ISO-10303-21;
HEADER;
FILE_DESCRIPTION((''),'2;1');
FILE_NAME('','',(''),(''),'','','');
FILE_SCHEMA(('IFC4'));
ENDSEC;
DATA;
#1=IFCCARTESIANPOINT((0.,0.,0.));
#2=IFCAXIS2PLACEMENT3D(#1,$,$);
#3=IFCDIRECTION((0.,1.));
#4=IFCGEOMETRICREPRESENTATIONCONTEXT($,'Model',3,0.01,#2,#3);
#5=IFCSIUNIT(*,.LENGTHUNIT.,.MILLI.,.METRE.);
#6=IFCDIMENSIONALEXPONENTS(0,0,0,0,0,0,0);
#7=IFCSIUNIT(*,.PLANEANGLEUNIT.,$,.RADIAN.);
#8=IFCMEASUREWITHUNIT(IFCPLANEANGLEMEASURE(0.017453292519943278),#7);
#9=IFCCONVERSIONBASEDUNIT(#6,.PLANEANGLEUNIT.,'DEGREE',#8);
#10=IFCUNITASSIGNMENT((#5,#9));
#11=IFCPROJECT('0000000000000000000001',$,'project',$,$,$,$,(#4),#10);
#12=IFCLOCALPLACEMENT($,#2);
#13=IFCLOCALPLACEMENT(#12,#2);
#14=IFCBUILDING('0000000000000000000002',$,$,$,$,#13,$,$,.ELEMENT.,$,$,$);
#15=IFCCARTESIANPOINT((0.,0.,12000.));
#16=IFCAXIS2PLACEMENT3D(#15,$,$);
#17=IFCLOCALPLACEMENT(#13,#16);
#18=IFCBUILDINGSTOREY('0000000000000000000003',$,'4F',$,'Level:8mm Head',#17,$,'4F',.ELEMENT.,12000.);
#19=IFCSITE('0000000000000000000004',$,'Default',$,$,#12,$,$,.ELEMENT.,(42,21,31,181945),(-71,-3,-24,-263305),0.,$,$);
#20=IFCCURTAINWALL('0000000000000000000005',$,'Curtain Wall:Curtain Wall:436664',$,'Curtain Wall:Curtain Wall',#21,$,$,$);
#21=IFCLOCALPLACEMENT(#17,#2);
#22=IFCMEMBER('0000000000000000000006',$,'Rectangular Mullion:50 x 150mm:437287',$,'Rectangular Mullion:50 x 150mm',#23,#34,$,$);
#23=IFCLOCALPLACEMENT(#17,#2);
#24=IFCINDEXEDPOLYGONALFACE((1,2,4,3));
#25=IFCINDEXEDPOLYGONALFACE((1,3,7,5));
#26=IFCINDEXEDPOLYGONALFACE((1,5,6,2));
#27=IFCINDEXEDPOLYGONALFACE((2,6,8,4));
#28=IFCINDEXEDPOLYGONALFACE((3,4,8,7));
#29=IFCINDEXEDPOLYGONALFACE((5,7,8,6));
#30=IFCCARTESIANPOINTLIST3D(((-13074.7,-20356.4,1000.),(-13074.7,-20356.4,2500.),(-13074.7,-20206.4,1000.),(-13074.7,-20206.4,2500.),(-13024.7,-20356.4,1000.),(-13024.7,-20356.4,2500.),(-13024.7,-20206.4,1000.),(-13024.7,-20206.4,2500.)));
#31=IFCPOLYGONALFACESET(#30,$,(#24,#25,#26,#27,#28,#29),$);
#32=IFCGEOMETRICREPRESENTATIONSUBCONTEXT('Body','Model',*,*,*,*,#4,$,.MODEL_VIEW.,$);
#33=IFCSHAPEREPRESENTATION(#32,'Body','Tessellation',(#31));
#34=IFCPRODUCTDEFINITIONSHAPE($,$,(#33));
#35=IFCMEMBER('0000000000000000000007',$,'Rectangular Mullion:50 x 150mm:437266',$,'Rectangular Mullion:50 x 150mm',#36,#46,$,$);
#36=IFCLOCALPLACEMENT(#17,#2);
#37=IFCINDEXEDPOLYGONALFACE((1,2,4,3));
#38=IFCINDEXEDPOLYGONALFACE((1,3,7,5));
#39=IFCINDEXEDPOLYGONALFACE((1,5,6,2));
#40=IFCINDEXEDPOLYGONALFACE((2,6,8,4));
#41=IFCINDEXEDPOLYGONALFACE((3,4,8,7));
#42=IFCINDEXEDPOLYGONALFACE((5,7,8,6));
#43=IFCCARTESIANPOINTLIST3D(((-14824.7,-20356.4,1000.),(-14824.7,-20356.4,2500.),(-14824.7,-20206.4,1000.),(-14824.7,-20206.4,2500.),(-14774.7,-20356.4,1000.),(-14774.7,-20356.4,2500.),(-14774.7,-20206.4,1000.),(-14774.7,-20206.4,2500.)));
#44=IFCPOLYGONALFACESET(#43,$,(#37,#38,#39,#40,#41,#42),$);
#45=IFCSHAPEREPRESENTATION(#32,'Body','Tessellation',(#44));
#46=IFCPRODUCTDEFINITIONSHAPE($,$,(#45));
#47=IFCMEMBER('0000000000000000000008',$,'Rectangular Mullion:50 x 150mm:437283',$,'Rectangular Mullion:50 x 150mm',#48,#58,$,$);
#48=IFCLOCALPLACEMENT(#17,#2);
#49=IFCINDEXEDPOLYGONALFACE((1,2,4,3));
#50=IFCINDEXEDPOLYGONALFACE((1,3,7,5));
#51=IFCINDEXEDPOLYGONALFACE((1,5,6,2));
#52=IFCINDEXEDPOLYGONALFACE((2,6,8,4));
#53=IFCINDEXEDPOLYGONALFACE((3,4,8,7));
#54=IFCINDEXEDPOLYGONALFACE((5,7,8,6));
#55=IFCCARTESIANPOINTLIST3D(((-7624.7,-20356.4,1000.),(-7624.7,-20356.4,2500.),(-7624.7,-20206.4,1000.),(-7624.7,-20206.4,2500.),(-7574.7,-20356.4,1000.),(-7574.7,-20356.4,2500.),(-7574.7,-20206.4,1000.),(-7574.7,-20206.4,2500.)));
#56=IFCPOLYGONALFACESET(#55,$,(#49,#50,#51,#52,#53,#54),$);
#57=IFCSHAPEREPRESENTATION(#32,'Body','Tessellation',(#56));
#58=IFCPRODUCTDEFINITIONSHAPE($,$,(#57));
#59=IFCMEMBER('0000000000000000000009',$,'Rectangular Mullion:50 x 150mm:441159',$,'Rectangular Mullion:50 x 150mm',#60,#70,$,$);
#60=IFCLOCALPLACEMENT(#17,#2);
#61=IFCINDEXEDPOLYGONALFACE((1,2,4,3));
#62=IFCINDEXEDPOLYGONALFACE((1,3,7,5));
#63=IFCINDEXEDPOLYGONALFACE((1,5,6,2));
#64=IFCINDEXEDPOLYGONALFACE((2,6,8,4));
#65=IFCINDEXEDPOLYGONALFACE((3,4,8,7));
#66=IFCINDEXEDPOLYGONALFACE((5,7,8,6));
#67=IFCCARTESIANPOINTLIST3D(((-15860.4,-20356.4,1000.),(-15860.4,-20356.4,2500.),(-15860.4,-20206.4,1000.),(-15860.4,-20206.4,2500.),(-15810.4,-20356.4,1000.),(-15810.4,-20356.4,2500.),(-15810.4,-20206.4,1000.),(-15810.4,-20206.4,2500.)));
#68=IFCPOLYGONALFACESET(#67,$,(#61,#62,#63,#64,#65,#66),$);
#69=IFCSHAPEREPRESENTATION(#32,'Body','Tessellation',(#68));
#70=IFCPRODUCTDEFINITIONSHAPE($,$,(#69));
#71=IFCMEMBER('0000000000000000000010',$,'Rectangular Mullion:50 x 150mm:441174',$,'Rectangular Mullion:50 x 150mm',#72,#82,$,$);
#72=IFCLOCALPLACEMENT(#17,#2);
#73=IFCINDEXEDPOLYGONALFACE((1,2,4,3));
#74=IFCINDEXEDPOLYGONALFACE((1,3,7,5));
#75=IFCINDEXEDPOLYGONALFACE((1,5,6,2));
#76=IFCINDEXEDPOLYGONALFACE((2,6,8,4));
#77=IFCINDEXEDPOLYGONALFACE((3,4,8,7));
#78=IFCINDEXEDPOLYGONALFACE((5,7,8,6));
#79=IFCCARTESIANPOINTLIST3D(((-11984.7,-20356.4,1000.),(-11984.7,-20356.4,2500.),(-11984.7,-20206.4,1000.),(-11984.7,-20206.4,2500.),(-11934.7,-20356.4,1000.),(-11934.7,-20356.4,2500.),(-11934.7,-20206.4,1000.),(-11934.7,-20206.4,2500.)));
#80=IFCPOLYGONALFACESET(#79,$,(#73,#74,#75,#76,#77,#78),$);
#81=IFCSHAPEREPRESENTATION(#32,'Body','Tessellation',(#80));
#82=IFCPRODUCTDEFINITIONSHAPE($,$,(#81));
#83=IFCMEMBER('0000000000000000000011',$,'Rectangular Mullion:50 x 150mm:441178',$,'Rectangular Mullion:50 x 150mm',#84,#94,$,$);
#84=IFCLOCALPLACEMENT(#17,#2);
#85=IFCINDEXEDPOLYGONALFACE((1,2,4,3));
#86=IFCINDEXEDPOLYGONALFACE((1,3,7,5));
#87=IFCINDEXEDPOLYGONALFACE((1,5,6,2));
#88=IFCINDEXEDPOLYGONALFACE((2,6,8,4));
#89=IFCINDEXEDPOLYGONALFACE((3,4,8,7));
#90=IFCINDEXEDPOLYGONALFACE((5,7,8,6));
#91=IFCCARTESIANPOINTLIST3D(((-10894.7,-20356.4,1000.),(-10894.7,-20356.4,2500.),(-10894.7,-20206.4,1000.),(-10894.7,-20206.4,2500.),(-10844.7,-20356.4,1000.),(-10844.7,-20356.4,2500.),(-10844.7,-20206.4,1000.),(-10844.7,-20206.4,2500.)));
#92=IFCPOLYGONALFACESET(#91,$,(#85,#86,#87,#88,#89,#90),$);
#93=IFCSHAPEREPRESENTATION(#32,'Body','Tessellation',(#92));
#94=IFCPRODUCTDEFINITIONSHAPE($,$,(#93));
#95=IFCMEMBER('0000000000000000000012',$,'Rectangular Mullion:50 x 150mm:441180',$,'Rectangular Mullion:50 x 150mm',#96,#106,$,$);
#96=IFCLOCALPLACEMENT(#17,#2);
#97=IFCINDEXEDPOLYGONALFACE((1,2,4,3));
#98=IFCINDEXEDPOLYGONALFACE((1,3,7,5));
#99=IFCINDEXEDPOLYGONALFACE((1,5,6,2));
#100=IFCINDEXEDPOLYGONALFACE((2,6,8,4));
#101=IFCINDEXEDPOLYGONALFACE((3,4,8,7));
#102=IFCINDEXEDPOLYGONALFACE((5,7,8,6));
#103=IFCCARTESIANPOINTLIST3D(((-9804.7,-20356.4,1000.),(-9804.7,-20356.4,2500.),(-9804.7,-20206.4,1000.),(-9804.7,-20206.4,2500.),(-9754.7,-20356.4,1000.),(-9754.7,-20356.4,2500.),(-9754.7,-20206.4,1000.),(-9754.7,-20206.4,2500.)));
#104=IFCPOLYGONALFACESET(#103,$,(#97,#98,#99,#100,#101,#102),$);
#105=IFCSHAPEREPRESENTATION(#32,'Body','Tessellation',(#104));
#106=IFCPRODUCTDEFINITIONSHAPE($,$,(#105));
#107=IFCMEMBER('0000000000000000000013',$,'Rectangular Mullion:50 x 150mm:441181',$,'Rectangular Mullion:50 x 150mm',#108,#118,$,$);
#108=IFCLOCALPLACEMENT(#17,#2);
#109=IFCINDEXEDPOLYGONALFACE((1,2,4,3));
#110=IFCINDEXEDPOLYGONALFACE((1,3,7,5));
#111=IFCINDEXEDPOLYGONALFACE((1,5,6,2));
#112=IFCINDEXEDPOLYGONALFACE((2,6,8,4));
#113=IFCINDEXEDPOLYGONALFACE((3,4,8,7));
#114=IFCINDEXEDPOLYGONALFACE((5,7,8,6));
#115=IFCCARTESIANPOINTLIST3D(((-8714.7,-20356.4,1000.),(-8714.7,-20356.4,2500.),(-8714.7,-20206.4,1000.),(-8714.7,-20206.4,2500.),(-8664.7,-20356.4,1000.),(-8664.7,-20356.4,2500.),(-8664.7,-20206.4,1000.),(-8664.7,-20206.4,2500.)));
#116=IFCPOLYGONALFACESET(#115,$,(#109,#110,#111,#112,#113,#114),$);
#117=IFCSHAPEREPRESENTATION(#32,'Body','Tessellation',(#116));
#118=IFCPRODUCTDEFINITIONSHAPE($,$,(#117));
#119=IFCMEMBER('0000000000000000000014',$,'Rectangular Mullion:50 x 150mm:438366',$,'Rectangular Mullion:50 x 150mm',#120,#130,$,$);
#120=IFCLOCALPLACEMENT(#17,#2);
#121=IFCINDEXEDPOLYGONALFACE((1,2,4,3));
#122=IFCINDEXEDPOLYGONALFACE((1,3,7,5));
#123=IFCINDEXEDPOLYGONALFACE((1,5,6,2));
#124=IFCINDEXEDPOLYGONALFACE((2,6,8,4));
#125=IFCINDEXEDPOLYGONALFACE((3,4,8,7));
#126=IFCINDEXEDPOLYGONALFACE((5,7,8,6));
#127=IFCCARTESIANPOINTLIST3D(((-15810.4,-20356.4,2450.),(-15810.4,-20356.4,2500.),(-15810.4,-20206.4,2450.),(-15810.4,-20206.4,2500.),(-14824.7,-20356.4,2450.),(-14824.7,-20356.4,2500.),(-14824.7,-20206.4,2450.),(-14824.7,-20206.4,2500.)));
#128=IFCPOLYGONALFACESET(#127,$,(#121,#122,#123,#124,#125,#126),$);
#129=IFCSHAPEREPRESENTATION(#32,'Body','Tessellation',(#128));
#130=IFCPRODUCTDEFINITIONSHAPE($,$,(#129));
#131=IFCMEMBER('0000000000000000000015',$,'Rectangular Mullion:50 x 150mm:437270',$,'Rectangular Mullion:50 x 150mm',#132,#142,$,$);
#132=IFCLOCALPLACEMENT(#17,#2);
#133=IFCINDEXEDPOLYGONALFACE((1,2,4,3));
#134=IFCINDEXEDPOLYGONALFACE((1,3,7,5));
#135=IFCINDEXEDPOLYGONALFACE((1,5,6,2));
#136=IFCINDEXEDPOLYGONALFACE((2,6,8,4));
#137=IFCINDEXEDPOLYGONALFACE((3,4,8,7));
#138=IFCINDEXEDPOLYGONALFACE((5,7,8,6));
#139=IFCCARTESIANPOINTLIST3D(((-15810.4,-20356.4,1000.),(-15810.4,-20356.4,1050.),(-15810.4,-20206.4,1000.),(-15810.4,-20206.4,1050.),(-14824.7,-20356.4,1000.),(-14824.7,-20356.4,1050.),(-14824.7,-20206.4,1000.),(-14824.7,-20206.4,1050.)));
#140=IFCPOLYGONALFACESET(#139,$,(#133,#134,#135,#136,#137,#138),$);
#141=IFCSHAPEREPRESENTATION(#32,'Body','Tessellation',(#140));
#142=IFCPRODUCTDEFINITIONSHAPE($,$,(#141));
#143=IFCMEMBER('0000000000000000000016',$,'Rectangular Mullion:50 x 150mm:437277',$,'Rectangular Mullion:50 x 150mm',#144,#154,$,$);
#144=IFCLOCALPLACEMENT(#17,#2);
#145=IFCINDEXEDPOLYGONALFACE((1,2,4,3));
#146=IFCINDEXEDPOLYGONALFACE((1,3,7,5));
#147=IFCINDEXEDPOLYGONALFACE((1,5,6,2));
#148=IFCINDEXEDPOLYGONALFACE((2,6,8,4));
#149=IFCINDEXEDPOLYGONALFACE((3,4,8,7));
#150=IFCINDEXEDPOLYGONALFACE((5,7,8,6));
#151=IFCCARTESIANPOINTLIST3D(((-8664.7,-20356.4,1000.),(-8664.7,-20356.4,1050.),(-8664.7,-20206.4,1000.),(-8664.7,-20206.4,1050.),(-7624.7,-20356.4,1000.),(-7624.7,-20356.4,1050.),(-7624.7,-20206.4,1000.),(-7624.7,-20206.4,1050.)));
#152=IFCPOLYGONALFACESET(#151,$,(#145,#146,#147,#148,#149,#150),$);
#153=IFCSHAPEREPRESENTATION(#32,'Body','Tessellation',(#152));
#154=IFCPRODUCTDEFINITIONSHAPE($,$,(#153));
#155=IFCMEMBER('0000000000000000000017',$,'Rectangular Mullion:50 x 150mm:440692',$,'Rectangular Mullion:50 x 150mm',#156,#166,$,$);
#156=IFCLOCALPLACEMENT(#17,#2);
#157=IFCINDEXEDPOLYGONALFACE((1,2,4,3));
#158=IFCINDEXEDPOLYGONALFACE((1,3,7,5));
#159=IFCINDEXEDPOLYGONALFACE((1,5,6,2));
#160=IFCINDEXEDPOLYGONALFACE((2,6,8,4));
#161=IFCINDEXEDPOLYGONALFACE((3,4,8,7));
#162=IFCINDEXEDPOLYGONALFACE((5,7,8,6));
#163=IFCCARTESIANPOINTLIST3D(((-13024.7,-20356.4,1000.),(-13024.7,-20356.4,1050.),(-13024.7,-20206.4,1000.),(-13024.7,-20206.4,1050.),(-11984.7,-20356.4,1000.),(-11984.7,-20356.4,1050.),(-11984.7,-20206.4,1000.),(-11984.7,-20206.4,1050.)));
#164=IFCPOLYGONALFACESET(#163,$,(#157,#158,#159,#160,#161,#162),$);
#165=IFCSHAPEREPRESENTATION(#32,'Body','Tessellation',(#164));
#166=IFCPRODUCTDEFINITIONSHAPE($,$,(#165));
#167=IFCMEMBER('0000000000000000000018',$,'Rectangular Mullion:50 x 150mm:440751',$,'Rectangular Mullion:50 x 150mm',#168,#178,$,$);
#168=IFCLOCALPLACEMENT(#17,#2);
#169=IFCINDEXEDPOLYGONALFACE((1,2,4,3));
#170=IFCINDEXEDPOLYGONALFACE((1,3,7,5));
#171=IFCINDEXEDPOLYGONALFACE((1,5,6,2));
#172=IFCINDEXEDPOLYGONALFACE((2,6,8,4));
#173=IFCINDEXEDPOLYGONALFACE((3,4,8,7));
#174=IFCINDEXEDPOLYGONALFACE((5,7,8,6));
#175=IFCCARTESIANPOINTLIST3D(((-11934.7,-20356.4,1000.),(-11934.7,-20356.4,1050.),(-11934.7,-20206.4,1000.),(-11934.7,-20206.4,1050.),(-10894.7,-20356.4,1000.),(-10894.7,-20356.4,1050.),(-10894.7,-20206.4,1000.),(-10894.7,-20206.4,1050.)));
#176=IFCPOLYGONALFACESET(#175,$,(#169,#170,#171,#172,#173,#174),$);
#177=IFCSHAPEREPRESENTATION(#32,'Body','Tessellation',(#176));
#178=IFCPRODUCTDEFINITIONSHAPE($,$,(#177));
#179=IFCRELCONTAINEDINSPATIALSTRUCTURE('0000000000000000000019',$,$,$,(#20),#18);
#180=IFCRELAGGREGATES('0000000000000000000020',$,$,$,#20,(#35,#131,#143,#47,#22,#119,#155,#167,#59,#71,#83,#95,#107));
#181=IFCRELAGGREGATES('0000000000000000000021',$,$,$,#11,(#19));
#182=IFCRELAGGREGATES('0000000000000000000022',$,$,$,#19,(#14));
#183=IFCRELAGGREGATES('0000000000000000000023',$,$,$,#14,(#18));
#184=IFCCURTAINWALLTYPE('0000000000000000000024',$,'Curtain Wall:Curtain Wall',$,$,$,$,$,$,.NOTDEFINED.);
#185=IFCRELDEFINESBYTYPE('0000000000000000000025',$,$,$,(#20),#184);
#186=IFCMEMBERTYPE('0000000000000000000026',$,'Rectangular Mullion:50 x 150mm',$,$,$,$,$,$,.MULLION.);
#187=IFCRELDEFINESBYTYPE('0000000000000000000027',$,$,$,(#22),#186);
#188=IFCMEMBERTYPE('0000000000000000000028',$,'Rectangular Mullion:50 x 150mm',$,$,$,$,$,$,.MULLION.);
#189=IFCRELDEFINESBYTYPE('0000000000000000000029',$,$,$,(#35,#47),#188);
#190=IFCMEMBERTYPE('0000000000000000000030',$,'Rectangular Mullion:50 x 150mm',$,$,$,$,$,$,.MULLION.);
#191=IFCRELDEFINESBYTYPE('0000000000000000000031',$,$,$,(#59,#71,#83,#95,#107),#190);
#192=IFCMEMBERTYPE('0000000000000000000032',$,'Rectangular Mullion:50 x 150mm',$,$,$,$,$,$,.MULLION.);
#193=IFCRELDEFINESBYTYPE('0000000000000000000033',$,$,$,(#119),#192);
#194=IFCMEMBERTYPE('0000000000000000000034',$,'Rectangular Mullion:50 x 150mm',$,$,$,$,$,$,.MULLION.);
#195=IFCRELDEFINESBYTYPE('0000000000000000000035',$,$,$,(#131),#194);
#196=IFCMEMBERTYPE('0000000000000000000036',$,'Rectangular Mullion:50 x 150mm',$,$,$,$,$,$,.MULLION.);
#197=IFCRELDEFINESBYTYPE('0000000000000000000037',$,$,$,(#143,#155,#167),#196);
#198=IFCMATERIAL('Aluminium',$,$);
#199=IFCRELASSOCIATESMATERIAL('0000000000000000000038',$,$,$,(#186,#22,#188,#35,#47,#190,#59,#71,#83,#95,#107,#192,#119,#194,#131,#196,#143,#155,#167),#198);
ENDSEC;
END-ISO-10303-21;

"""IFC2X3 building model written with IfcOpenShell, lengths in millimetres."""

from ifc_helpers import new_model, entity, si_unit, converted_unit, direction, frame, origin, origin_2d_with_axis, place, context, subcontext, project, spatial, rectangle, extrude, source, transform, mapped, material, type_object, type_shapes, element, aggregate, save


model = new_model("IFC2X3")

# Units and contexts
model_context = context("Model", 3, precision=0.01, world=origin(), true_north=direction((0.0, 1.0)))
body_context = subcontext(model_context, "Body", "Model", "MODEL_VIEW")
ifc_project = project(units=[si_unit("LENGTHUNIT", "METRE", prefix="MILLI"), converted_unit("PLANEANGLEUNIT", "DEGREE", entity("IfcPlaneAngleMeasure", 0.017453292519943278), si_unit("PLANEANGLEUNIT", "RADIAN"), dimensions=[0, 0, 0, 0, 0, 0, 0])], contexts=[model_context])

# Site, building, storey
site_placement = place(None, origin())
site = spatial("IfcSite", under=ifc_project, at=site_placement, Name="Default", CompositionType="ELEMENT", RefLatitude=(42, 21, 31, 181945), RefLongitude=(-71, -3, -24, -263305), RefElevation=0.0)
building_placement = place(site_placement, origin())
building = spatial("IfcBuilding", under=site, at=building_placement, CompositionType="ELEMENT")
storey_placement = place(building_placement, frame((0.0, 0.0, 12000.0)))
storey = spatial("IfcBuildingStorey", under=building, at=storey_placement, Name="4F", ObjectType="Level:8mm Head", LongName="4F", CompositionType="ELEMENT", Elevation=12000.0)

# Curtain wall, members
curtain_wall_type = type_object("IfcCurtainWallType", Name="Curtain Wall:Curtain Wall", PredefinedType="NOTDEFINED")
curtain_wall_placement = place(storey_placement, frame((0.0, 0.0, -12000.0)))
curtain_wall = element("IfcCurtainWall", 1, at=curtain_wall_placement, inside=storey, type_object=curtain_wall_type, Name="Curtain Wall:Curtain Wall:436664", ObjectType="Curtain Wall:Curtain Wall")
ifc_material_1 = material(Name="Aluminium")
member_type_1 = type_object("IfcMemberType", Name="Rectangular Mullion:50 x 150mm", PredefinedType="MULLION", material=ifc_material_1)
shared_shape_1 = source(origin(), body_context, "Body", "SweptSolid", [
    extrude(rectangle(XDim=50.0, YDim=150.0, at=origin_2d_with_axis()), frame((-25.0, 0.0, -1500.0), z_axis=(0.0, 0.0, 1.0), x_axis=(-1.0, 0.0, 0.0)), (0.0, 0.0, 1.0), 1500.0),
])
type_shapes(member_type_1, [shared_shape_1])
member_1_placement = place(curtain_wall_placement, frame((-13074.7, -20281.4, 13000.0), z_axis=(0.0, 0.0, -1.0), x_axis=(-1.0, 0.0, 0.0)))
member_1 = element("IfcMember", 2, at=member_1_placement, type_object=member_type_1, material=ifc_material_1, Name="Rectangular Mullion:50 x 150mm:437287", ObjectType="Rectangular Mullion:50 x 150mm", context=body_context, shape_type="MappedRepresentation", body=[
    mapped(shared_shape_1, transform((0.0, 0.0, 0.0), scale=1.0)),
])
member_type_2 = type_object("IfcMemberType", Name="Rectangular Mullion:50 x 150mm", PredefinedType="MULLION", material=ifc_material_1)
shared_shape_2 = source(origin(), body_context, "Body", "SweptSolid", [
    extrude(rectangle(XDim=50.0, YDim=150.0, at=origin_2d_with_axis()), frame((-25.0, 0.0, -1500.0), z_axis=(0.0, 0.0, 1.0), x_axis=(-1.0, 0.0, 0.0)), (0.0, 0.0, 1.0), 1500.0),
])
type_shapes(member_type_2, [shared_shape_2])
member_2_placement = place(curtain_wall_placement, frame((-14774.7, -20281.4, 14500.0)))
member_2 = element("IfcMember", 3, at=member_2_placement, type_object=member_type_2, material=ifc_material_1, Name="Rectangular Mullion:50 x 150mm:437266", ObjectType="Rectangular Mullion:50 x 150mm", context=body_context, shape_type="MappedRepresentation", body=[
    mapped(shared_shape_2, transform((0.0, 0.0, 0.0), scale=1.0)),
])
member_3_placement = place(curtain_wall_placement, frame((-7574.7, -20281.4, 14500.0)))
member_3 = element("IfcMember", 4, at=member_3_placement, type_object=member_type_2, material=ifc_material_1, Name="Rectangular Mullion:50 x 150mm:437283", ObjectType="Rectangular Mullion:50 x 150mm", context=body_context, shape_type="MappedRepresentation", body=[
    mapped(shared_shape_2, transform((0.0, 0.0, 0.0), scale=1.0)),
])
member_type_3 = type_object("IfcMemberType", Name="Rectangular Mullion:50 x 150mm", PredefinedType="MULLION", material=ifc_material_1)
shared_shape_3 = source(origin(), body_context, "Body", "SweptSolid", [
    extrude(rectangle(XDim=50.0, YDim=150.0, at=origin_2d_with_axis()), frame((0.0, 0.0, -1500.0), z_axis=(0.0, 0.0, 1.0), x_axis=(-1.0, 0.0, 0.0)), (0.0, 0.0, 1.0), 1500.0),
])
type_shapes(member_type_3, [shared_shape_3])
member_4_placement = place(curtain_wall_placement, frame((-15835.4, -20281.4, 13000.0), z_axis=(0.0, 0.0, -1.0), x_axis=(-1.0, 0.0, 0.0)))
member_4 = element("IfcMember", 5, at=member_4_placement, type_object=member_type_3, material=ifc_material_1, Name="Rectangular Mullion:50 x 150mm:441159", ObjectType="Rectangular Mullion:50 x 150mm", context=body_context, shape_type="MappedRepresentation", body=[
    mapped(shared_shape_3, transform((0.0, 0.0, 0.0), scale=1.0)),
])
member_5_placement = place(curtain_wall_placement, frame((-11959.7, -20281.4, 13000.0), z_axis=(0.0, 0.0, -1.0), x_axis=(-1.0, 0.0, 0.0)))
member_5 = element("IfcMember", 6, at=member_5_placement, type_object=member_type_3, material=ifc_material_1, Name="Rectangular Mullion:50 x 150mm:441174", ObjectType="Rectangular Mullion:50 x 150mm", context=body_context, shape_type="MappedRepresentation", body=[
    mapped(shared_shape_3, transform((0.0, 0.0, 0.0), scale=1.0)),
])
member_6_placement = place(curtain_wall_placement, frame((-10869.7, -20281.4, 13000.0), z_axis=(0.0, 0.0, -1.0), x_axis=(-1.0, 0.0, 0.0)))
member_6 = element("IfcMember", 7, at=member_6_placement, type_object=member_type_3, material=ifc_material_1, Name="Rectangular Mullion:50 x 150mm:441178", ObjectType="Rectangular Mullion:50 x 150mm", context=body_context, shape_type="MappedRepresentation", body=[
    mapped(shared_shape_3, transform((0.0, 0.0, 0.0), scale=1.0)),
])
member_7_placement = place(curtain_wall_placement, frame((-9779.7, -20281.4, 13000.0), z_axis=(0.0, 0.0, -1.0), x_axis=(-1.0, 0.0, 0.0)))
member_7 = element("IfcMember", 8, at=member_7_placement, type_object=member_type_3, material=ifc_material_1, Name="Rectangular Mullion:50 x 150mm:441180", ObjectType="Rectangular Mullion:50 x 150mm", context=body_context, shape_type="MappedRepresentation", body=[
    mapped(shared_shape_3, transform((0.0, 0.0, 0.0), scale=1.0)),
])
member_8_placement = place(curtain_wall_placement, frame((-8689.7, -20281.4, 13000.0), z_axis=(0.0, 0.0, -1.0), x_axis=(-1.0, 0.0, 0.0)))
member_8 = element("IfcMember", 9, at=member_8_placement, type_object=member_type_3, material=ifc_material_1, Name="Rectangular Mullion:50 x 150mm:441181", ObjectType="Rectangular Mullion:50 x 150mm", context=body_context, shape_type="MappedRepresentation", body=[
    mapped(shared_shape_3, transform((0.0, 0.0, 0.0), scale=1.0)),
])
member_type_4 = type_object("IfcMemberType", Name="Rectangular Mullion:50 x 150mm", PredefinedType="MULLION", material=ifc_material_1)
shared_shape_4 = source(origin(), body_context, "Body", "SweptSolid", [
    extrude(rectangle(XDim=50.0, YDim=150.0, at=origin_2d_with_axis()), frame((-25.0, 0.0, -985.7), z_axis=(0.0, 0.0, 1.0), x_axis=(-1.0, 0.0, 0.0)), (0.0, 0.0, 1.0), 985.7),
])
type_shapes(member_type_4, [shared_shape_4])
member_9_placement = place(curtain_wall_placement, frame((-15810.4, -20281.4, 14500.0), z_axis=(-1.0, 0.0, 0.0), x_axis=(0.0, 0.0, 1.0)))
member_9 = element("IfcMember", 10, at=member_9_placement, type_object=member_type_4, material=ifc_material_1, Name="Rectangular Mullion:50 x 150mm:438366", ObjectType="Rectangular Mullion:50 x 150mm", context=body_context, shape_type="MappedRepresentation", body=[
    mapped(shared_shape_4, transform((0.0, 0.0, 0.0), scale=1.0)),
])
member_type_5 = type_object("IfcMemberType", Name="Rectangular Mullion:50 x 150mm", PredefinedType="MULLION", material=ifc_material_1)
shared_shape_5 = source(origin(), body_context, "Body", "SweptSolid", [
    extrude(rectangle(XDim=50.0, YDim=150.0, at=origin_2d_with_axis()), frame((-25.0, 0.0, -985.7), z_axis=(0.0, 0.0, 1.0), x_axis=(-1.0, 0.0, 0.0)), (0.0, 0.0, 1.0), 985.7),
])
type_shapes(member_type_5, [shared_shape_5])
member_10_placement = place(curtain_wall_placement, frame((-14824.7, -20281.4, 13000.0), z_axis=(1.0, 0.0, 0.0), x_axis=(0.0, 0.0, -1.0)))
member_10 = element("IfcMember", 11, at=member_10_placement, type_object=member_type_5, material=ifc_material_1, Name="Rectangular Mullion:50 x 150mm:437270", ObjectType="Rectangular Mullion:50 x 150mm", context=body_context, shape_type="MappedRepresentation", body=[
    mapped(shared_shape_5, transform((0.0, 0.0, 0.0), scale=1.0)),
])
member_type_6 = type_object("IfcMemberType", Name="Rectangular Mullion:50 x 150mm", PredefinedType="MULLION", material=ifc_material_1)
shared_shape_6 = source(origin(), body_context, "Body", "SweptSolid", [
    extrude(rectangle(XDim=50.0, YDim=150.0, at=origin_2d_with_axis()), frame((-25.0, 0.0, -1040.0), z_axis=(0.0, 0.0, 1.0), x_axis=(-1.0, 0.0, 0.0)), (0.0, 0.0, 1.0), 1040.0),
])
type_shapes(member_type_6, [shared_shape_6])
member_11_placement = place(curtain_wall_placement, frame((-7624.7, -20281.4, 13000.0), z_axis=(1.0, 0.0, 0.0), x_axis=(0.0, 0.0, -1.0)))
member_11 = element("IfcMember", 12, at=member_11_placement, type_object=member_type_6, material=ifc_material_1, Name="Rectangular Mullion:50 x 150mm:437277", ObjectType="Rectangular Mullion:50 x 150mm", context=body_context, shape_type="MappedRepresentation", body=[
    mapped(shared_shape_6, transform((0.0, 0.0, 0.0), scale=1.0)),
])
member_12_placement = place(curtain_wall_placement, frame((-11984.7, -20281.4, 13000.0), z_axis=(1.0, 0.0, 0.0), x_axis=(0.0, 0.0, -1.0)))
member_12 = element("IfcMember", 13, at=member_12_placement, type_object=member_type_6, material=ifc_material_1, Name="Rectangular Mullion:50 x 150mm:440692", ObjectType="Rectangular Mullion:50 x 150mm", context=body_context, shape_type="MappedRepresentation", body=[
    mapped(shared_shape_6, transform((0.0, 0.0, 0.0), scale=1.0)),
])
member_13_placement = place(curtain_wall_placement, frame((-10894.7, -20281.4, 13000.0), z_axis=(1.0, 0.0, 0.0), x_axis=(0.0, 0.0, -1.0)))
member_13 = element("IfcMember", 14, at=member_13_placement, type_object=member_type_6, material=ifc_material_1, Name="Rectangular Mullion:50 x 150mm:440751", ObjectType="Rectangular Mullion:50 x 150mm", context=body_context, shape_type="MappedRepresentation", body=[
    mapped(shared_shape_6, transform((0.0, 0.0, 0.0), scale=1.0)),
])
aggregate(curtain_wall, [member_2, member_10, member_11, member_3, member_1, member_9, member_12, member_13, member_4, member_5, member_6, member_7, member_8])

save(model, "model.ifc")
